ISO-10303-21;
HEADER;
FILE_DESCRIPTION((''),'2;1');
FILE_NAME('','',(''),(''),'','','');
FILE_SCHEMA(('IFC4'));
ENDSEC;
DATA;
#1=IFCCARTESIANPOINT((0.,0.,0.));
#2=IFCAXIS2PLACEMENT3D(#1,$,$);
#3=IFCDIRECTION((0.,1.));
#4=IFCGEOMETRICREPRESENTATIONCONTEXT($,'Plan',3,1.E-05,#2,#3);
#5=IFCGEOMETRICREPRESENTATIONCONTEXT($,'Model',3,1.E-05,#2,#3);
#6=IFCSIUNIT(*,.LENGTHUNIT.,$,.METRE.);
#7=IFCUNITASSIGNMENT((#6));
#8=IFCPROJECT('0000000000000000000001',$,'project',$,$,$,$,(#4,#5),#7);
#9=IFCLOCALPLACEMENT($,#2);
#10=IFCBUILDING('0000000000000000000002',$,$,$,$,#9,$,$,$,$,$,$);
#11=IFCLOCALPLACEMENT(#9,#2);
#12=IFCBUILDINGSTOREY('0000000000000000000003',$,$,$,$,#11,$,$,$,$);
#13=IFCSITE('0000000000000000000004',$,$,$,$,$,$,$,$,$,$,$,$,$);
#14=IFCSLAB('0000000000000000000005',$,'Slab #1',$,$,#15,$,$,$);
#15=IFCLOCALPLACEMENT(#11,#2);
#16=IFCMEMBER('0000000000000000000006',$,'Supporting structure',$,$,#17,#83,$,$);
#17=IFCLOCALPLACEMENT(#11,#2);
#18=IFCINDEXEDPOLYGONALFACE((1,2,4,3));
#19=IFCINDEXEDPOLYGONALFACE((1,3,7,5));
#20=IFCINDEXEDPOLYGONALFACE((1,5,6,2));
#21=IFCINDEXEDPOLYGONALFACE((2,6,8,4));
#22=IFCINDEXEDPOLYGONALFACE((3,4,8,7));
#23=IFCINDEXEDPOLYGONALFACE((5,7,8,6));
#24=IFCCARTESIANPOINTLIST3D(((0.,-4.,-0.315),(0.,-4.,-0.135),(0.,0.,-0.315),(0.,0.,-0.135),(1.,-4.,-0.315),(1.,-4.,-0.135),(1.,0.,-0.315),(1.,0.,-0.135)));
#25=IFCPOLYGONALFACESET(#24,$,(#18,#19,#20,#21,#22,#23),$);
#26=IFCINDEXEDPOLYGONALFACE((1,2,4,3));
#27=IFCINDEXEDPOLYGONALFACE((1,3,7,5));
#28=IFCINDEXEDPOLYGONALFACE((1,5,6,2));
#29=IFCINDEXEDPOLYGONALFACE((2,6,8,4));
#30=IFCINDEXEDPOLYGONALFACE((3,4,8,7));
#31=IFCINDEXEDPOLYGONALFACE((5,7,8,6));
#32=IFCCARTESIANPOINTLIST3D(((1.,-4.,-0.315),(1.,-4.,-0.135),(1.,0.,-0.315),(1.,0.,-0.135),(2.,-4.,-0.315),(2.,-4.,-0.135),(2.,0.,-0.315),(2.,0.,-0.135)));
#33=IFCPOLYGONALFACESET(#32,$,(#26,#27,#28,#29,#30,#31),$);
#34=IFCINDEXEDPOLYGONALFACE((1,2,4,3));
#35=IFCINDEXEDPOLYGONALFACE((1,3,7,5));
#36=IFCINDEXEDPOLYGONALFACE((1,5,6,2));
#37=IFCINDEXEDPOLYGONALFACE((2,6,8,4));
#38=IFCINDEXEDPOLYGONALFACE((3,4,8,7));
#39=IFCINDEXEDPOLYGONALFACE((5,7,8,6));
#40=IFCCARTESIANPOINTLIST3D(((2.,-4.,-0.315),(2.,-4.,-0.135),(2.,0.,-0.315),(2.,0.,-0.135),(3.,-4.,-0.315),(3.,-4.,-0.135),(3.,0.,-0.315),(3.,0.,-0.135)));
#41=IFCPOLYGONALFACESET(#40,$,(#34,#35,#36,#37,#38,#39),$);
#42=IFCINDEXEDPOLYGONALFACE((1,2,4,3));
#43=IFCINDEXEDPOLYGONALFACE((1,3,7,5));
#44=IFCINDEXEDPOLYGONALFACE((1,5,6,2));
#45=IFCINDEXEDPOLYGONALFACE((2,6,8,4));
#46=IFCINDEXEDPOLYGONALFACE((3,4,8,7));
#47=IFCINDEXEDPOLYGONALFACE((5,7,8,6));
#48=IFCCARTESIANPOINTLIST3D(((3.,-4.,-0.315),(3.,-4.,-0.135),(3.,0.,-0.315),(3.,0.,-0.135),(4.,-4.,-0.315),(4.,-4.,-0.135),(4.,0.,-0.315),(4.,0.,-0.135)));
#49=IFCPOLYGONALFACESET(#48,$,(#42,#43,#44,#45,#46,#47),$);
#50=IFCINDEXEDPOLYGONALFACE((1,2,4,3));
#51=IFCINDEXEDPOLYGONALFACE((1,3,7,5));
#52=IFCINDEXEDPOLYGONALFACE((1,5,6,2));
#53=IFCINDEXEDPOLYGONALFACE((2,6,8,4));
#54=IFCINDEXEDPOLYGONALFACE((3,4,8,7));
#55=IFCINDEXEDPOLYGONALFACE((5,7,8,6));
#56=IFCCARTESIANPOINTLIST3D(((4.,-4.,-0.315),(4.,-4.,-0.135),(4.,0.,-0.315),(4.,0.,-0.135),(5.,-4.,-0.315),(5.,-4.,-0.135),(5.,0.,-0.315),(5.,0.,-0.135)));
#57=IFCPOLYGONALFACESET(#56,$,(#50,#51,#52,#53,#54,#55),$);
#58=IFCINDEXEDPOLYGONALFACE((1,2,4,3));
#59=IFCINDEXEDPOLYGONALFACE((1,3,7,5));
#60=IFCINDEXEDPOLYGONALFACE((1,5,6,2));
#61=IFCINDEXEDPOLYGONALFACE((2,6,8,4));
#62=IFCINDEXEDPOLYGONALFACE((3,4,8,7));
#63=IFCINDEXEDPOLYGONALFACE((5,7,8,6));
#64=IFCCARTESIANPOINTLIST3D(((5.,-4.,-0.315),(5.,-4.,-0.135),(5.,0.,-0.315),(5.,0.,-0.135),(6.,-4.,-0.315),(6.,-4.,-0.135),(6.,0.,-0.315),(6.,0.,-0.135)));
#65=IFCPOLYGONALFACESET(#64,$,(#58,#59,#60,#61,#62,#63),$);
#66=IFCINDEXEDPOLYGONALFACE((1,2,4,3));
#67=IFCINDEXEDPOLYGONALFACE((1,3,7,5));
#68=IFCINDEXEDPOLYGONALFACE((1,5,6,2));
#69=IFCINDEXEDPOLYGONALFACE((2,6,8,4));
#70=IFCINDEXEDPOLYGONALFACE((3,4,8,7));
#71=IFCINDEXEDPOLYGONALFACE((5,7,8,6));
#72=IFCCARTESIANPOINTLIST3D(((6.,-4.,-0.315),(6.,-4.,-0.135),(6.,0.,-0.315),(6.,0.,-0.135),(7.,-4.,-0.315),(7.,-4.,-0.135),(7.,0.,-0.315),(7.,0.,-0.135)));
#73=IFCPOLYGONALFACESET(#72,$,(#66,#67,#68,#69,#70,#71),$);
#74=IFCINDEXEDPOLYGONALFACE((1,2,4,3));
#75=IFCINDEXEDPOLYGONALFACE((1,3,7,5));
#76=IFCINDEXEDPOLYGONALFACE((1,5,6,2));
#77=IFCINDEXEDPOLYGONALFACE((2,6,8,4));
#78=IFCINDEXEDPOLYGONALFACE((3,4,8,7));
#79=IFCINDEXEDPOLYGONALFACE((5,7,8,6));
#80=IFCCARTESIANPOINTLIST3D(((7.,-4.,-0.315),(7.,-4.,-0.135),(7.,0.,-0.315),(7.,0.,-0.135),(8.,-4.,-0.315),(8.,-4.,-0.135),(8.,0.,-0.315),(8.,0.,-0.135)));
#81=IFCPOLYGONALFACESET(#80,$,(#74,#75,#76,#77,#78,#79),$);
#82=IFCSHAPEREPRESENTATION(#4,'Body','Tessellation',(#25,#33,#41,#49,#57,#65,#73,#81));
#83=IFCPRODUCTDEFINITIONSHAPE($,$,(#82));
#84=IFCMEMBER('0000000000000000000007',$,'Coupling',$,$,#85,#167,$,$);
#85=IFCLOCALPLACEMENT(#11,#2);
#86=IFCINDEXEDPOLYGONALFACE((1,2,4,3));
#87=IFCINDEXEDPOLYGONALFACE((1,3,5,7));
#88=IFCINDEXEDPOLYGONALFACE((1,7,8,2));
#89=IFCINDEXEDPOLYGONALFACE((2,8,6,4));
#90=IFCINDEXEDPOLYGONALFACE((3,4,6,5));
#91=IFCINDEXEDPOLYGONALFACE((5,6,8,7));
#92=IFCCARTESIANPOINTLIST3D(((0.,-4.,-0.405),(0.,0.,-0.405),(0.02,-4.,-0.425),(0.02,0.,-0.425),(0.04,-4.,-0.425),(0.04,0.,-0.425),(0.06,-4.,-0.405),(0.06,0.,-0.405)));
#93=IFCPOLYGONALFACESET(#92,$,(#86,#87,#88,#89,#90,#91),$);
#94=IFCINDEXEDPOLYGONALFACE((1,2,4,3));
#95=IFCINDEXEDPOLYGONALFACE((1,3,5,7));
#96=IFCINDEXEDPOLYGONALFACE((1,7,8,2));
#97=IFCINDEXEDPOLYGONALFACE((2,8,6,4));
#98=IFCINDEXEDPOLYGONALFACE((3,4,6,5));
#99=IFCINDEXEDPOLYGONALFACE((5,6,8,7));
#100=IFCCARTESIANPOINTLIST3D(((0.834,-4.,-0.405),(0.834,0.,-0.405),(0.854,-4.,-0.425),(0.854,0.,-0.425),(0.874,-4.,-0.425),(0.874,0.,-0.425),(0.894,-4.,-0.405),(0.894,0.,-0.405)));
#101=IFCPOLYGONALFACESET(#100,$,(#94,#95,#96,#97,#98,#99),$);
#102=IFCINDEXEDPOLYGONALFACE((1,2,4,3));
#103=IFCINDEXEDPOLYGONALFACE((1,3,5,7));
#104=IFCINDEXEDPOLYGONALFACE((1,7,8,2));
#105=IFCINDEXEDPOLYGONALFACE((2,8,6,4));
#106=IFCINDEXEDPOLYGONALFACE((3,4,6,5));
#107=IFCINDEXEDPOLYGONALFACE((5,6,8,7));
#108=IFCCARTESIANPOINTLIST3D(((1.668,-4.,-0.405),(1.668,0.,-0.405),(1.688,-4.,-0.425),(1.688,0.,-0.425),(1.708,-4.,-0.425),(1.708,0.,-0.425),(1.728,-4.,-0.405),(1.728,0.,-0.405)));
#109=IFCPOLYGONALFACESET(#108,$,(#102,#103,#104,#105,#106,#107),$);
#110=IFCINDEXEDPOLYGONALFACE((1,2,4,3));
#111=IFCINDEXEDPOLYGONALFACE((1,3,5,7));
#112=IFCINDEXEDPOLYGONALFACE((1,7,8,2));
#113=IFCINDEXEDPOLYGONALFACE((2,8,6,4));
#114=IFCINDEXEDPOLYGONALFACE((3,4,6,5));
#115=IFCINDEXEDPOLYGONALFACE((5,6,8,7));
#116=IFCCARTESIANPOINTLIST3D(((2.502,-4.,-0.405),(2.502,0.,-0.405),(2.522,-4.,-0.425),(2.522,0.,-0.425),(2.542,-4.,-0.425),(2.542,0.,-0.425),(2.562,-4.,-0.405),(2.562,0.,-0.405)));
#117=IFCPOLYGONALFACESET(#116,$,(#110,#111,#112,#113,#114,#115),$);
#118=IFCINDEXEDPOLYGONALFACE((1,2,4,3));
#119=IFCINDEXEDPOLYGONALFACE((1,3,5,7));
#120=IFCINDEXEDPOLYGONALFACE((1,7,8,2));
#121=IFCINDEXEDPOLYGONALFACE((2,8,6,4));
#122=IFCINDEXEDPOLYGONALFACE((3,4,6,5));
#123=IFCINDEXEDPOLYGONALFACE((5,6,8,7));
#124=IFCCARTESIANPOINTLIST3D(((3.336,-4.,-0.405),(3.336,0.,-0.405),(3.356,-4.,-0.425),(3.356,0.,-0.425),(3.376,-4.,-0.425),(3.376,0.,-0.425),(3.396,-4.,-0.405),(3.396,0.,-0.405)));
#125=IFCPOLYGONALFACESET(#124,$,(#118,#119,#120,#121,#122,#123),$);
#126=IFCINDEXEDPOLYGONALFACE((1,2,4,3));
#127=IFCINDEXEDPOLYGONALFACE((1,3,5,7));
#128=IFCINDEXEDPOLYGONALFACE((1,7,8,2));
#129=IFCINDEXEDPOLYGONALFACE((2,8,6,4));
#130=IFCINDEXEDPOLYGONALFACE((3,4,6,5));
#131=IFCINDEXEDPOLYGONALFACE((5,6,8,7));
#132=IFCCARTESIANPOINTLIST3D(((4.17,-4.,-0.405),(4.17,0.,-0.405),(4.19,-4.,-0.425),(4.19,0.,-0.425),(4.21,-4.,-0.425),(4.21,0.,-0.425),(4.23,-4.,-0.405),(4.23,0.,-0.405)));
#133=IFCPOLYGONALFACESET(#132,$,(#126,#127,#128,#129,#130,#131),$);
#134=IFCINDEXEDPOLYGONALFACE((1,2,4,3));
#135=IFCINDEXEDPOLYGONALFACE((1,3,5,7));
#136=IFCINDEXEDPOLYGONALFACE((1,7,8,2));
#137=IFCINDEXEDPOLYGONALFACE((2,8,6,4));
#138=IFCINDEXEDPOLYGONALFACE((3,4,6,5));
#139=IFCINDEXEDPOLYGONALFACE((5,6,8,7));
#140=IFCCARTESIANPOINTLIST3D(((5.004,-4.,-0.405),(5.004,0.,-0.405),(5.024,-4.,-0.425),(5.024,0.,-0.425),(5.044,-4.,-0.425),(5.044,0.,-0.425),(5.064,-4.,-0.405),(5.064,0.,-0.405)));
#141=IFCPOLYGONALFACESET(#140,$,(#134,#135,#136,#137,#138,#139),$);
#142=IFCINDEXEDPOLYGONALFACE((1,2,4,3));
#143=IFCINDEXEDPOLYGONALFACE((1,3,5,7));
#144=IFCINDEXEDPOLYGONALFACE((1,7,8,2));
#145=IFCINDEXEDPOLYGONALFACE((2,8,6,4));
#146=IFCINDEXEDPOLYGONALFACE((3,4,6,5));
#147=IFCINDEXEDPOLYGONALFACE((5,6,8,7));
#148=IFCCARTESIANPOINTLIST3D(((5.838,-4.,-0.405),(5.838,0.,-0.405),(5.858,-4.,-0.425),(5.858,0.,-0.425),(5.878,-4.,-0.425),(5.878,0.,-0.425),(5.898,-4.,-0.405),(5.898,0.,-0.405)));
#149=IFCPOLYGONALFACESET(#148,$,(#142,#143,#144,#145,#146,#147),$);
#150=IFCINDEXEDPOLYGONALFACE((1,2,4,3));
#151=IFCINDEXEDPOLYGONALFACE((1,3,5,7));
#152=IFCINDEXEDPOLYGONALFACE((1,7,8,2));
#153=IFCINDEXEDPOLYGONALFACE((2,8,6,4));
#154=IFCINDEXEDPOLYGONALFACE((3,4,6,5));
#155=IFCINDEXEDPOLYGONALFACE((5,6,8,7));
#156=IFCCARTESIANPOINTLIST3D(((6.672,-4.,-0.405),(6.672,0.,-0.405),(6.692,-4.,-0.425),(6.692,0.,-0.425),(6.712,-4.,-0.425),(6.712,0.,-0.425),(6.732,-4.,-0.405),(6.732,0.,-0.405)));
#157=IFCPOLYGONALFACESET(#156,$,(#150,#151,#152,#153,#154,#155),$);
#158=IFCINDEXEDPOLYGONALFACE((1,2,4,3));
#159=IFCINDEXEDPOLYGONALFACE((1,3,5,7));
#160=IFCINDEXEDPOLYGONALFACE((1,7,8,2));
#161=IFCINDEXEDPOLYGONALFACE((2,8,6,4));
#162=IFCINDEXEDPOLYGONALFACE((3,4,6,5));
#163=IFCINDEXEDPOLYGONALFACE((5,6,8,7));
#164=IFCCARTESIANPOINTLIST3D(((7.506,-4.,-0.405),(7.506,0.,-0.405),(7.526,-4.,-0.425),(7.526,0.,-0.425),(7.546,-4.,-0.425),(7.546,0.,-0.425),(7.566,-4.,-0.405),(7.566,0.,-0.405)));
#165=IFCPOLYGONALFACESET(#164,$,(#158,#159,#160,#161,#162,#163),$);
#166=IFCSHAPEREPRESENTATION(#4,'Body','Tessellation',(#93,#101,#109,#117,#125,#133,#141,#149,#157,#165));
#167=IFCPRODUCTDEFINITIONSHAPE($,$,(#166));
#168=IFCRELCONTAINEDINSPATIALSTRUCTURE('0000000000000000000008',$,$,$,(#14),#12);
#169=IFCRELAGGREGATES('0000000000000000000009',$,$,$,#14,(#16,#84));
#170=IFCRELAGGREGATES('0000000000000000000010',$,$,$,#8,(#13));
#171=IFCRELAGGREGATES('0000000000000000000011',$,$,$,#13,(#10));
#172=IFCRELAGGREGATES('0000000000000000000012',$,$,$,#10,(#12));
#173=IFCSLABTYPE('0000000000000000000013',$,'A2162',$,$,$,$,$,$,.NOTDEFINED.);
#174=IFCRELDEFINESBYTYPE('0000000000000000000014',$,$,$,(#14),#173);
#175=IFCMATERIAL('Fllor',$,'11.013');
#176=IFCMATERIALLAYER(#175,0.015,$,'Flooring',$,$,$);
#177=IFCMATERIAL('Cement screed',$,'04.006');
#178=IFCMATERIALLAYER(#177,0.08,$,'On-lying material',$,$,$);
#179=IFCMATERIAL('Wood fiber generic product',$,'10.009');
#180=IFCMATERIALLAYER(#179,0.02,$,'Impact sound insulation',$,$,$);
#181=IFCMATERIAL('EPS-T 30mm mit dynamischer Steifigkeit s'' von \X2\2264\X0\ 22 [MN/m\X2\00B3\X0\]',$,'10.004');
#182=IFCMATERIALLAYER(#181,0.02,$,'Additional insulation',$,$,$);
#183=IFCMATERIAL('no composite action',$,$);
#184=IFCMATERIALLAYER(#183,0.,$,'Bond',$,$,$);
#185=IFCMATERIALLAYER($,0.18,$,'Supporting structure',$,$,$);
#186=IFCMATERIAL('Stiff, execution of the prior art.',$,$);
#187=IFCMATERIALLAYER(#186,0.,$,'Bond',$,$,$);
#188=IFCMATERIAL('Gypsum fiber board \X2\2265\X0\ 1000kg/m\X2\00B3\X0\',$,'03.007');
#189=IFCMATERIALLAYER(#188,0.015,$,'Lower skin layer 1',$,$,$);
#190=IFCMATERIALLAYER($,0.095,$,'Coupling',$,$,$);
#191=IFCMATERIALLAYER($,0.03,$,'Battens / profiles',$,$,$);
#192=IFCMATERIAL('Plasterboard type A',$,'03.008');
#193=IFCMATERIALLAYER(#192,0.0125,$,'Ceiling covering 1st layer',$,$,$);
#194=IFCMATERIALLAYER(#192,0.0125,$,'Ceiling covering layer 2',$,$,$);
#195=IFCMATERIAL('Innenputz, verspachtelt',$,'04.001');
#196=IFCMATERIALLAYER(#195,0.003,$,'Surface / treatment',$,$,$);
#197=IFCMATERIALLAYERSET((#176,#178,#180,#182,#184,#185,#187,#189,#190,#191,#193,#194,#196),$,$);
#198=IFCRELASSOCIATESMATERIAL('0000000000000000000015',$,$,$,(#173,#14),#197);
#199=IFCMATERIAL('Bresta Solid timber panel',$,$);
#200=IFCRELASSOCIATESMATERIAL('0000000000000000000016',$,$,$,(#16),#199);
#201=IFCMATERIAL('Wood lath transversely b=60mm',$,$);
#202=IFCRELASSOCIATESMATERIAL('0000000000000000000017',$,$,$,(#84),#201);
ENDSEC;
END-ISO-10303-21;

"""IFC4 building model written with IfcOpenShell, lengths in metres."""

from ifc_helpers import new_model, si_unit, direction, frame, frame_2d, origin, place, context, project, spatial, polyline, rectangle, outline, extrude, material, layer, layer_set, type_object, element, aggregate, save


model = new_model("IFC4")

# Units and contexts
plan_context = context("Plan", 3, precision=1e-05, world=origin(), true_north=direction((0.0, 1.0)))
model_context = context("Model", 3, precision=1e-05, world=origin(), true_north=direction((0.0, 1.0)))
ifc_project = project(units=[si_unit("LENGTHUNIT", "METRE")], contexts=[plan_context, model_context])

# Site, building, storey
site = spatial("IfcSite", under=ifc_project)
building_placement = place(None, origin())
building = spatial("IfcBuilding", under=site, at=building_placement)
storey_placement = place(building_placement, origin())
storey = spatial("IfcBuildingStorey", under=building, at=storey_placement)

# Slab, members
ifc_material_1 = material(Name="Fllor", Category="11.013")
ifc_layer_1 = layer(ifc_material_1, 0.015, Name="Flooring")
ifc_material_2 = material(Name="Cement screed", Category="04.006")
ifc_layer_2 = layer(ifc_material_2, 0.08, Name="On-lying material")
ifc_material_3 = material(Name="Wood fiber generic product", Category="10.009")
ifc_layer_3 = layer(ifc_material_3, 0.02, Name="Impact sound insulation")
ifc_material_4 = material(Name="EPS-T 30mm mit dynamischer Steifigkeit s' von ≤ 22 [MN/m³]", Category="10.004")
ifc_layer_4 = layer(ifc_material_4, 0.02, Name="Additional insulation")
ifc_material_5 = material(Name="no composite action")
ifc_layer_5 = layer(ifc_material_5, 0.0, Name="Bond")
ifc_layer_6 = layer(None, 0.18, Name="Supporting structure")
ifc_material_6 = material(Name="Stiff, execution of the prior art.")
ifc_layer_7 = layer(ifc_material_6, 0.0, Name="Bond")
ifc_material_7 = material(Name="Gypsum fiber board ≥ 1000kg/m³", Category="03.007")
ifc_layer_8 = layer(ifc_material_7, 0.015, Name="Lower skin layer 1")
ifc_layer_9 = layer(None, 0.095, Name="Coupling")
ifc_layer_10 = layer(None, 0.03, Name="Battens / profiles")
ifc_material_8 = material(Name="Plasterboard type A", Category="03.008")
ifc_layer_11 = layer(ifc_material_8, 0.0125, Name="Ceiling covering 1st layer")
ifc_layer_12 = layer(ifc_material_8, 0.0125, Name="Ceiling covering layer 2")
ifc_material_9 = material(Name="Innenputz, verspachtelt", Category="04.001")
ifc_layer_13 = layer(ifc_material_9, 0.003, Name="Surface / treatment")
ifc_layer_set = layer_set([ifc_layer_1, ifc_layer_2, ifc_layer_3, ifc_layer_4, ifc_layer_5, ifc_layer_6, ifc_layer_7, ifc_layer_8, ifc_layer_9, ifc_layer_10, ifc_layer_11, ifc_layer_12, ifc_layer_13])
slab_type = type_object("IfcSlabType", Name="A2162", PredefinedType="NOTDEFINED", material=ifc_layer_set)
slab_placement = place(None, frame((0.0, 0.0, 0.0), z_axis=(0.0, 0.0, -1.0), x_axis=(1.0, 0.0, 0.0)))
slab = element("IfcSlab", 1, at=slab_placement, inside=storey, type_object=slab_type, material=ifc_layer_set, Name="Slab #1")
ifc_material_10 = material(Name="Bresta Solid timber panel")
member_1_placement = place(slab_placement, origin())
member_1 = element("IfcMember", 2, at=member_1_placement, material=ifc_material_10, Name="Supporting structure", context=plan_context, shape_type="SweptSolid", body=[
    extrude(rectangle(XDim=1.0, YDim=0.18, at=frame_2d((0.5, 0.09), x_axis=(1.0, 0.0))), frame((0.0, 4.0, 0.135), z_axis=(0.0, -1.0, 0.0), x_axis=(1.0, 0.0, 0.0)), (0.0, 0.0, 1.0), 4.0),
    extrude(rectangle(XDim=1.0, YDim=0.18, at=frame_2d((0.5, 0.09), x_axis=(1.0, 0.0))), frame((1.0, 4.0, 0.135), z_axis=(0.0, -1.0, 0.0), x_axis=(1.0, 0.0, 0.0)), (0.0, 0.0, 1.0), 4.0),
    extrude(rectangle(XDim=1.0, YDim=0.18, at=frame_2d((0.5, 0.09), x_axis=(1.0, 0.0))), frame((2.0, 4.0, 0.135), z_axis=(0.0, -1.0, 0.0), x_axis=(1.0, 0.0, 0.0)), (0.0, 0.0, 1.0), 4.0),
    extrude(rectangle(XDim=1.0, YDim=0.18, at=frame_2d((0.5, 0.09), x_axis=(1.0, 0.0))), frame((3.0, 4.0, 0.135), z_axis=(0.0, -1.0, 0.0), x_axis=(1.0, 0.0, 0.0)), (0.0, 0.0, 1.0), 4.0),
    extrude(rectangle(XDim=1.0, YDim=0.18, at=frame_2d((0.5, 0.09), x_axis=(1.0, 0.0))), frame((4.0, 4.0, 0.135), z_axis=(0.0, -1.0, 0.0), x_axis=(1.0, 0.0, 0.0)), (0.0, 0.0, 1.0), 4.0),
    extrude(rectangle(XDim=1.0, YDim=0.18, at=frame_2d((0.5, 0.09), x_axis=(1.0, 0.0))), frame((5.0, 4.0, 0.135), z_axis=(0.0, -1.0, 0.0), x_axis=(1.0, 0.0, 0.0)), (0.0, 0.0, 1.0), 4.0),
    extrude(rectangle(XDim=1.0, YDim=0.18, at=frame_2d((0.5, 0.09), x_axis=(1.0, 0.0))), frame((6.0, 4.0, 0.135), z_axis=(0.0, -1.0, 0.0), x_axis=(1.0, 0.0, 0.0)), (0.0, 0.0, 1.0), 4.0),
    extrude(rectangle(XDim=1.0, YDim=0.18, at=frame_2d((0.5, 0.09), x_axis=(1.0, 0.0))), frame((7.0, 4.0, 0.135), z_axis=(0.0, -1.0, 0.0), x_axis=(1.0, 0.0, 0.0)), (0.0, 0.0, 1.0), 4.0),
])
ifc_material_11 = material(Name="Wood lath transversely b=60mm")
member_2_placement = place(slab_placement, origin())
member_2 = element("IfcMember", 3, at=member_2_placement, material=ifc_material_11, Name="Coupling", context=plan_context, shape_type="SweptSolid", body=[
    extrude(outline(polyline([(0.0, 0.0), (0.06, 0.0), (0.04, 0.02), (0.02, 0.02), (0.0, 0.0)])), frame((0.0, 4.0, 0.405), z_axis=(0.0, -1.0, 0.0), x_axis=(1.0, 0.0, 0.0)), (0.0, 0.0, 1.0), 4.0),
    extrude(outline(polyline([(0.0, 0.0), (0.06, 0.0), (0.04, 0.02), (0.02, 0.02), (0.0, 0.0)])), frame((0.834, 4.0, 0.405), z_axis=(0.0, -1.0, 0.0), x_axis=(1.0, 0.0, 0.0)), (0.0, 0.0, 1.0), 4.0),
    extrude(outline(polyline([(0.0, 0.0), (0.06, 0.0), (0.04, 0.02), (0.02, 0.02), (0.0, 0.0)])), frame((1.668, 4.0, 0.405), z_axis=(0.0, -1.0, 0.0), x_axis=(1.0, 0.0, 0.0)), (0.0, 0.0, 1.0), 4.0),
    extrude(outline(polyline([(0.0, 0.0), (0.06, 0.0), (0.04, 0.02), (0.02, 0.02), (0.0, 0.0)])), frame((2.502, 4.0, 0.405), z_axis=(0.0, -1.0, 0.0), x_axis=(1.0, 0.0, 0.0)), (0.0, 0.0, 1.0), 4.0),
    extrude(outline(polyline([(0.0, 0.0), (0.06, 0.0), (0.04, 0.02), (0.02, 0.02), (0.0, 0.0)])), frame((3.336, 4.0, 0.405), z_axis=(0.0, -1.0, 0.0), x_axis=(1.0, 0.0, 0.0)), (0.0, 0.0, 1.0), 4.0),
    extrude(outline(polyline([(0.0, 0.0), (0.06, 0.0), (0.04, 0.02), (0.02, 0.02), (0.0, 0.0)])), frame((4.17, 4.0, 0.405), z_axis=(0.0, -1.0, 0.0), x_axis=(1.0, 0.0, 0.0)), (0.0, 0.0, 1.0), 4.0),
    extrude(outline(polyline([(0.0, 0.0), (0.06, 0.0), (0.04, 0.02), (0.02, 0.02), (0.0, 0.0)])), frame((5.004, 4.0, 0.405), z_axis=(0.0, -1.0, 0.0), x_axis=(1.0, 0.0, 0.0)), (0.0, 0.0, 1.0), 4.0),
    extrude(outline(polyline([(0.0, 0.0), (0.06, 0.0), (0.04, 0.02), (0.02, 0.02), (0.0, 0.0)])), frame((5.838, 4.0, 0.405), z_axis=(0.0, -1.0, 0.0), x_axis=(1.0, 0.0, 0.0)), (0.0, 0.0, 1.0), 4.0),
    extrude(outline(polyline([(0.0, 0.0), (0.06, 0.0), (0.04, 0.02), (0.02, 0.02), (0.0, 0.0)])), frame((6.672, 4.0, 0.405), z_axis=(0.0, -1.0, 0.0), x_axis=(1.0, 0.0, 0.0)), (0.0, 0.0, 1.0), 4.0),
    extrude(outline(polyline([(0.0, 0.0), (0.06, 0.0), (0.04, 0.02), (0.02, 0.02), (0.0, 0.0)])), frame((7.506, 4.0, 0.405), z_axis=(0.0, -1.0, 0.0), x_axis=(1.0, 0.0, 0.0)), (0.0, 0.0, 1.0), 4.0),
])
aggregate(slab, [member_1, member_2])

save(model, "model.ifc")
